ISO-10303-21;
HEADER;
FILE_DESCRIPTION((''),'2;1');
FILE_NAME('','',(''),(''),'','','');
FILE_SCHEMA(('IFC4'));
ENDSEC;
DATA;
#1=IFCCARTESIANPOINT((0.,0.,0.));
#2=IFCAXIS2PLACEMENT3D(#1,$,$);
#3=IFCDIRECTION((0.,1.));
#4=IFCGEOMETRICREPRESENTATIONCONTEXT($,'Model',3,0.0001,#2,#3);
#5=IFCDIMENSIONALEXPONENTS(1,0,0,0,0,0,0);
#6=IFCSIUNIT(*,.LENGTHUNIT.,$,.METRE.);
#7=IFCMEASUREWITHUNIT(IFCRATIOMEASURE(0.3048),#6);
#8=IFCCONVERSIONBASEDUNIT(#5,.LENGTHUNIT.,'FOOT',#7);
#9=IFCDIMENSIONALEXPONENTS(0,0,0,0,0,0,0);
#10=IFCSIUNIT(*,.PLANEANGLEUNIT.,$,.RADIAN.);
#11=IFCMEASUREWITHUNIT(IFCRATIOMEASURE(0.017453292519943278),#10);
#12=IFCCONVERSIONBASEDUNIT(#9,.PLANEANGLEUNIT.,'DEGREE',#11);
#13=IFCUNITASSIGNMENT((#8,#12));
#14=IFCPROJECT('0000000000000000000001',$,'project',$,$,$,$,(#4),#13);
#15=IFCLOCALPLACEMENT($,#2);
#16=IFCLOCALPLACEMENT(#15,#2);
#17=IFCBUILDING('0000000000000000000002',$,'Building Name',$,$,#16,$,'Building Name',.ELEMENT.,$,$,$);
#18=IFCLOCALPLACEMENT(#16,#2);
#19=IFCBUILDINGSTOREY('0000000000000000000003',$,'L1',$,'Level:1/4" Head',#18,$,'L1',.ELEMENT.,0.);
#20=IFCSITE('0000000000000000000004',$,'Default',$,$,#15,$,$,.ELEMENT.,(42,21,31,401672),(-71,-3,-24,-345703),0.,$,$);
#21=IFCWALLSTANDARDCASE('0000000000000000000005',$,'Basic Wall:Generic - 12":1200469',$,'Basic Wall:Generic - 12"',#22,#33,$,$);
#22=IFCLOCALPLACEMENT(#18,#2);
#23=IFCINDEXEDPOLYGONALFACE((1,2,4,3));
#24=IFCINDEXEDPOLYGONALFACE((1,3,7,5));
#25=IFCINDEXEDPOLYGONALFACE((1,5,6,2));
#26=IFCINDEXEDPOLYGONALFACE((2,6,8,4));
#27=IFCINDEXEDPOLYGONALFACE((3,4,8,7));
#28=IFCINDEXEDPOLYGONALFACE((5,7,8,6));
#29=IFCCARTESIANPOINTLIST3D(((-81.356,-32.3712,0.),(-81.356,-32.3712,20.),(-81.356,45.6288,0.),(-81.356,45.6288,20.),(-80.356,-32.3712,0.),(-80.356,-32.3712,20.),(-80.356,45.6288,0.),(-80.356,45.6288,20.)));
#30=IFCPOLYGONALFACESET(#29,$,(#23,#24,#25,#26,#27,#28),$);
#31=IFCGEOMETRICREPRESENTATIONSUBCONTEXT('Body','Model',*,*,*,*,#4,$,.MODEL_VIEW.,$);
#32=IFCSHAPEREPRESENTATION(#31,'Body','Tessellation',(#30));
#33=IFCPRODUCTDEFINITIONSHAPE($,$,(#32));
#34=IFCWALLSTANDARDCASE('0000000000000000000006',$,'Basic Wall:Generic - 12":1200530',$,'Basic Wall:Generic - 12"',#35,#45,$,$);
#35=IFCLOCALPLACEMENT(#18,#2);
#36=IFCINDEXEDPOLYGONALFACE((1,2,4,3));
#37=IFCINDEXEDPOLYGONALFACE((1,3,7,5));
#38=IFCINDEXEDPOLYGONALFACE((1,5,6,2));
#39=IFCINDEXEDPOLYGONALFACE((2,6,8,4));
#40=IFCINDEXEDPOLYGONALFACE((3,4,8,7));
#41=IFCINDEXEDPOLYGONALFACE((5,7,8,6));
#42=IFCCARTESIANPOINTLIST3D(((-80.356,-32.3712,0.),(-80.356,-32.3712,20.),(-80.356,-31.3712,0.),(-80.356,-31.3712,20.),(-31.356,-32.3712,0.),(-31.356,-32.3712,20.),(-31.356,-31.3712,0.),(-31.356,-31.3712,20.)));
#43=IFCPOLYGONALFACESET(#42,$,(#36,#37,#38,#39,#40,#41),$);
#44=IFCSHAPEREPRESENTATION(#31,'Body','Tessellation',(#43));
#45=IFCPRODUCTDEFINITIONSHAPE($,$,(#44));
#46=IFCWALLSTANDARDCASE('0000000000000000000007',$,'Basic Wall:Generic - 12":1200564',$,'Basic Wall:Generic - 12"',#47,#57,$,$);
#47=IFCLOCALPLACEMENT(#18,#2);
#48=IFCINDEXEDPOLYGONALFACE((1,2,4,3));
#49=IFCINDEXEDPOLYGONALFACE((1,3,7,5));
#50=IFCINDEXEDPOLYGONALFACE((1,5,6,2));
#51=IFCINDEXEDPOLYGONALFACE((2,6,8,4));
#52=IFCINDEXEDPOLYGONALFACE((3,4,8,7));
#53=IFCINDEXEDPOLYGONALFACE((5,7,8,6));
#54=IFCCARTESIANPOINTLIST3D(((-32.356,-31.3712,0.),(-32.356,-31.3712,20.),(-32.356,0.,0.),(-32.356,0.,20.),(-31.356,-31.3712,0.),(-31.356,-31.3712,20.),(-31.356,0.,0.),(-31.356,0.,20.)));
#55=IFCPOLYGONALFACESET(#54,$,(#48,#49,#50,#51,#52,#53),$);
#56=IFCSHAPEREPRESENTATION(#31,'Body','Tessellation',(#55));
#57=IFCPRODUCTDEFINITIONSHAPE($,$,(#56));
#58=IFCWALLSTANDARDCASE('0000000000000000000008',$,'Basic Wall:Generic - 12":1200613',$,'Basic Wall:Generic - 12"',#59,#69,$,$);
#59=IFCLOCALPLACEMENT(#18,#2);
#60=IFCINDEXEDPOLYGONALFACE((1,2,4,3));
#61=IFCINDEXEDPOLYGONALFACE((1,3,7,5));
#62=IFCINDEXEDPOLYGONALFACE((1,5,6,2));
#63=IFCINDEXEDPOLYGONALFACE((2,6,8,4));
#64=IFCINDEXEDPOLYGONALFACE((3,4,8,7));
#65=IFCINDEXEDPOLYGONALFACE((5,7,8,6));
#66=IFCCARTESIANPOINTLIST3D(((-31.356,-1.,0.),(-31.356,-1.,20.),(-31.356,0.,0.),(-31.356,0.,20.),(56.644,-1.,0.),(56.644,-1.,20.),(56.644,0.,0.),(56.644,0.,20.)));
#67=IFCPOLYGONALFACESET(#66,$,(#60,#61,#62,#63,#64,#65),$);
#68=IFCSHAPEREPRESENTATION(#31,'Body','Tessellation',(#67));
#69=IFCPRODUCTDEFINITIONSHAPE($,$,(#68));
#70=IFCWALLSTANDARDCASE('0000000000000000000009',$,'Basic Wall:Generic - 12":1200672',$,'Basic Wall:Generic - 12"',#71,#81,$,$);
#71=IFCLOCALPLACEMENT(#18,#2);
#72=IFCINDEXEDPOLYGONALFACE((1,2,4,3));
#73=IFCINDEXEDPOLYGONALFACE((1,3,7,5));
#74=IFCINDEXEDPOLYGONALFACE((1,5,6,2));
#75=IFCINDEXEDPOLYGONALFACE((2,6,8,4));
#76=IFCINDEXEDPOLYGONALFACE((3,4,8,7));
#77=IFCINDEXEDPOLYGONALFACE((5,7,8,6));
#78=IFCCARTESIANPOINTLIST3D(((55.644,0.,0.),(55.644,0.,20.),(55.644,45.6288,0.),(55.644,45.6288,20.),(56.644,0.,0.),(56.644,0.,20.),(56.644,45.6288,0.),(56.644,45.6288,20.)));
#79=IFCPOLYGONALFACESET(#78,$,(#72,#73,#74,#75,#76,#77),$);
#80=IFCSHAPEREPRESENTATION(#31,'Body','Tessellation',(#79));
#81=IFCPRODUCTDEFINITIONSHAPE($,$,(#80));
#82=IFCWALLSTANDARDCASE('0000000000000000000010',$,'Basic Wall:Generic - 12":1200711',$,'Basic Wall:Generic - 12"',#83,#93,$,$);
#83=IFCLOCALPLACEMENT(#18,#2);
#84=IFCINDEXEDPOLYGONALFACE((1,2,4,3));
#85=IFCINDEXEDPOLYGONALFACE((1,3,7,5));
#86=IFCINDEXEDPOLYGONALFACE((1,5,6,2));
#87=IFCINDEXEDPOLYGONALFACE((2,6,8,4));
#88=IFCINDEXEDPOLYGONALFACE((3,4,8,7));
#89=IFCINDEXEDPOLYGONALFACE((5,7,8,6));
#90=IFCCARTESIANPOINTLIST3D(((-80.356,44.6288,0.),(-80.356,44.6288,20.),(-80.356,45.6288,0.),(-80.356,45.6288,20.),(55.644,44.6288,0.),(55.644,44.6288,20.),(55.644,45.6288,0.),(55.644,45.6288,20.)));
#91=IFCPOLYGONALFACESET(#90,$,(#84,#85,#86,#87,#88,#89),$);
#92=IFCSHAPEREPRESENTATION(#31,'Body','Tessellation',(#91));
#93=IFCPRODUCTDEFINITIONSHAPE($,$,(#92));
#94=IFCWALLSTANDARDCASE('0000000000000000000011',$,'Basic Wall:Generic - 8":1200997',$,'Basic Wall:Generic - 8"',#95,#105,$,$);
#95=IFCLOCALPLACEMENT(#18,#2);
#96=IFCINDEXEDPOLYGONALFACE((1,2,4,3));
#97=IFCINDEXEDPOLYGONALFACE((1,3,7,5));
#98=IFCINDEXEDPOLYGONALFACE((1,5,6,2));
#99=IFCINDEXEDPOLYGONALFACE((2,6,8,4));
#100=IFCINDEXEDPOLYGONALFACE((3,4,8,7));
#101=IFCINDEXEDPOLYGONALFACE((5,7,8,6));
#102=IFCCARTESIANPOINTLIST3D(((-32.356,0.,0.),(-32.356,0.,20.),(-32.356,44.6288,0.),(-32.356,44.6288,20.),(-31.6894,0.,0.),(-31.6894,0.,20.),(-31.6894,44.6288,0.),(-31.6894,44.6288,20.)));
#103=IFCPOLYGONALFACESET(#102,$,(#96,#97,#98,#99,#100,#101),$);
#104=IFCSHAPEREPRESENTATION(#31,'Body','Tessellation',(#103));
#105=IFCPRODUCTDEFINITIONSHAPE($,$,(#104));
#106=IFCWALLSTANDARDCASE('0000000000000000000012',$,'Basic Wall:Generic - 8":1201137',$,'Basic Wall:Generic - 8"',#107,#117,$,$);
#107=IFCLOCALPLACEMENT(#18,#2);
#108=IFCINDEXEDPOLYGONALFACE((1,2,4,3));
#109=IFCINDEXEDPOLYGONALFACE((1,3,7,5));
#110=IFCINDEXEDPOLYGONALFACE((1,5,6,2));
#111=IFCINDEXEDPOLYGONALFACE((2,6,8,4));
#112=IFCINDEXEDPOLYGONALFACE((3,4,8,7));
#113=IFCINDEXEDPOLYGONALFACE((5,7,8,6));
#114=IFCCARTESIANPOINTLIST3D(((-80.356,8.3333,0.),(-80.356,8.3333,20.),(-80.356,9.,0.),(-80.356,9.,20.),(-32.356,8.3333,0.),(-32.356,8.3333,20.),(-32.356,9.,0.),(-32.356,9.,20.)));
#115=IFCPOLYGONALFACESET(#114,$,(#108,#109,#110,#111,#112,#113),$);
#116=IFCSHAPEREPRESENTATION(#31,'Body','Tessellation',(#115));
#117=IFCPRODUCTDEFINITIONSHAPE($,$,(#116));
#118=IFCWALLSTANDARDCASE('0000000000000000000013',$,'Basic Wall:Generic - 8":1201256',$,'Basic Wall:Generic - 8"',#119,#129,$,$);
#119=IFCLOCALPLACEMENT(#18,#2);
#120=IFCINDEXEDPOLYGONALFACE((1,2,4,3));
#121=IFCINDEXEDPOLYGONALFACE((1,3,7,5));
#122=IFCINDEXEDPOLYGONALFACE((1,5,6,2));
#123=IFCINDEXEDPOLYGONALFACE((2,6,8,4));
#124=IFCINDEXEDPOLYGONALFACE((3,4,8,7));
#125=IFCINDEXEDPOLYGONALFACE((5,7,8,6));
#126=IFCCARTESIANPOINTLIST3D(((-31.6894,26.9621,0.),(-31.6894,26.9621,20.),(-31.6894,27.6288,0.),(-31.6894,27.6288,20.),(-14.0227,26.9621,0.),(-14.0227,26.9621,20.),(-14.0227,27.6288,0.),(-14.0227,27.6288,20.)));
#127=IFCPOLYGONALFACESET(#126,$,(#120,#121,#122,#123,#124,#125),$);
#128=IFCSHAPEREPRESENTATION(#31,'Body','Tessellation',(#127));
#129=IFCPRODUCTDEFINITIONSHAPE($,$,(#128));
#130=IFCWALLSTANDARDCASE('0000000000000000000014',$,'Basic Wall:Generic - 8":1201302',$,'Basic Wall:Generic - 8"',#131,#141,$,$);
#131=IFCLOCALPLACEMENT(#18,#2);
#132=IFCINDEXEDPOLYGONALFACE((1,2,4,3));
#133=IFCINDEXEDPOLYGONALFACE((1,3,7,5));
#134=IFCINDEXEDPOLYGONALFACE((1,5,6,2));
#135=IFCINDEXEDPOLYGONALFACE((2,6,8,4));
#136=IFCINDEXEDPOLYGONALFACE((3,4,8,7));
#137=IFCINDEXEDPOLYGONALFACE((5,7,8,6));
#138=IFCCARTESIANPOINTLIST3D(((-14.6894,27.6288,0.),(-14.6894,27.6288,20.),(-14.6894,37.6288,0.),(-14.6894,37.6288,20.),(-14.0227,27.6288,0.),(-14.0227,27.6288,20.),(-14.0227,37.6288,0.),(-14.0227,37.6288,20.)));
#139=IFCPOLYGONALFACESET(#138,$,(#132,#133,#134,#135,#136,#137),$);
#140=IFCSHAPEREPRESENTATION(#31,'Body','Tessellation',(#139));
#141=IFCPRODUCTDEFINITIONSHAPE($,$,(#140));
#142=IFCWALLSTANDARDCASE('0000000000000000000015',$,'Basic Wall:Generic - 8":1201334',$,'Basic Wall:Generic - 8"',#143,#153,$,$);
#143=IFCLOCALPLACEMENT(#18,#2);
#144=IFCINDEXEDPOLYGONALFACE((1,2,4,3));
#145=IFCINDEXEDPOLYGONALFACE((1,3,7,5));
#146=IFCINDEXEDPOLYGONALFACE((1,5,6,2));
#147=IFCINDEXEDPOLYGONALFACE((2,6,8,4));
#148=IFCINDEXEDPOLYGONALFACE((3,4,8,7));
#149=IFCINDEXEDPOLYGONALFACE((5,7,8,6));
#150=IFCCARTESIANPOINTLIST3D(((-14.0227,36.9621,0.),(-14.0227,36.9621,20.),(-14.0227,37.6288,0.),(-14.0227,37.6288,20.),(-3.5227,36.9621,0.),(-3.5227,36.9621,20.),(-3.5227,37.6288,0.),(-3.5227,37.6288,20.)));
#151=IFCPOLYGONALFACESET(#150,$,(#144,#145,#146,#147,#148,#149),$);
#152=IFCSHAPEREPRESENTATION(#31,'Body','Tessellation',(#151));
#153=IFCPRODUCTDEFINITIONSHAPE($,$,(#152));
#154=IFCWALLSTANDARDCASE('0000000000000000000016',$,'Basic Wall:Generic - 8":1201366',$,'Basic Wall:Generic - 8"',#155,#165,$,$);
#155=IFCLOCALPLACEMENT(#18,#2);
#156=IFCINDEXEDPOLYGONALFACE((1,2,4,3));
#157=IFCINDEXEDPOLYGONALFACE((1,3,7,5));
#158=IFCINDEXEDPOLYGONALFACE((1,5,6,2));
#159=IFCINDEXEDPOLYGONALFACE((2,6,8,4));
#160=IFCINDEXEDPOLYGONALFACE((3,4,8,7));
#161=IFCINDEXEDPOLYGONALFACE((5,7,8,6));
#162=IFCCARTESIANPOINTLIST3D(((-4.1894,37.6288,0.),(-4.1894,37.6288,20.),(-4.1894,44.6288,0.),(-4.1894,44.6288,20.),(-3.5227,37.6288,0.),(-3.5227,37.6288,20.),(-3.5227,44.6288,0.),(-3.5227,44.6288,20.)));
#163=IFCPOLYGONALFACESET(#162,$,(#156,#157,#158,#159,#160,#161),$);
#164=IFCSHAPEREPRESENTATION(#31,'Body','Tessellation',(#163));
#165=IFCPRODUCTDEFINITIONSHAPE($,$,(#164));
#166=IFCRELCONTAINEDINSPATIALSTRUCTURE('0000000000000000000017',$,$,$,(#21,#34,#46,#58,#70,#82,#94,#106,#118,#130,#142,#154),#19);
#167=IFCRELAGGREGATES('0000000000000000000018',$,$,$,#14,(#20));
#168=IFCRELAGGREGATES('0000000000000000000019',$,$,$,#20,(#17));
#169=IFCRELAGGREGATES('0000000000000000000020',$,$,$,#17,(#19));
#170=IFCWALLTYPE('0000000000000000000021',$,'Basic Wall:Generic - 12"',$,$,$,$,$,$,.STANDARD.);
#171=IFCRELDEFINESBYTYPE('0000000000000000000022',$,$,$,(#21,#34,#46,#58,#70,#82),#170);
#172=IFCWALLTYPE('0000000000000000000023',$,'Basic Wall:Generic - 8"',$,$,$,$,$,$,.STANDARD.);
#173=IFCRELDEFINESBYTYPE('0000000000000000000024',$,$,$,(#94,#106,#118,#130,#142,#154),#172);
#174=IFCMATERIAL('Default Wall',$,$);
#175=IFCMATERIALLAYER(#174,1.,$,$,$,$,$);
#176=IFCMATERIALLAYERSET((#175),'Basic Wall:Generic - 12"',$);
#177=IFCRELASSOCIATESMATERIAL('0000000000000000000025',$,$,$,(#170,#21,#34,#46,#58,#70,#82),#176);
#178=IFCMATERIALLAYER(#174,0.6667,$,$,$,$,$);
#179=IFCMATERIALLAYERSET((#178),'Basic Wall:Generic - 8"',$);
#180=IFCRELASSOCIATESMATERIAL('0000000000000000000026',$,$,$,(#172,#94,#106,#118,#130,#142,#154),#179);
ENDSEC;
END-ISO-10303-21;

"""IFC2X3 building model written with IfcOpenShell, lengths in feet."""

from ifc_helpers import new_model, entity, si_unit, converted_unit, direction, frame, frame_2d, origin, place, context, subcontext, project, spatial, rectangle, extrude, material, layer, layer_set, layer_usage, type_object, element, save


model = new_model("IFC2X3")

# Units and contexts
model_context = context("Model", 3, precision=0.0001, world=origin(), true_north=direction((0.0, 1.0)))
body_context = subcontext(model_context, "Body", "Model", "MODEL_VIEW")
ifc_project = project(units=[converted_unit("LENGTHUNIT", "FOOT", entity("IfcRatioMeasure", 0.3048), si_unit("LENGTHUNIT", "METRE"), dimensions=[1, 0, 0, 0, 0, 0, 0]), converted_unit("PLANEANGLEUNIT", "DEGREE", entity("IfcRatioMeasure", 0.017453292519943278), si_unit("PLANEANGLEUNIT", "RADIAN"), dimensions=[0, 0, 0, 0, 0, 0, 0])], contexts=[model_context])

# Site, building, storey
site_placement = place(None, origin())
site = spatial("IfcSite", under=ifc_project, at=site_placement, Name="Default", CompositionType="ELEMENT", RefLatitude=(42, 21, 31, 401672), RefLongitude=(-71, -3, -24, -345703), RefElevation=0.0)
building_placement = place(site_placement, origin())
building = spatial("IfcBuilding", under=site, at=building_placement, Name="Building Name", LongName="Building Name", CompositionType="ELEMENT")
storey_placement = place(building_placement, origin())
storey = spatial("IfcBuildingStorey", under=building, at=storey_placement, Name="L1", ObjectType="Level:1/4\" Head", LongName="L1", CompositionType="ELEMENT", Elevation=0.0)

# Walls
ifc_material = material(Name="Default Wall")
ifc_layer_1 = layer(ifc_material, 1.0)
ifc_layer_set_1 = layer_set([ifc_layer_1], Name="Basic Wall:Generic - 12\"")
ifc_layer_usage_1 = layer_usage(ifc_layer_set_1, "AXIS2", "NEGATIVE", 0.5)
wall_type_1 = type_object("IfcWallType", Name="Basic Wall:Generic - 12\"", PredefinedType="STANDARD", material=ifc_layer_set_1)
wall_1_placement = place(storey_placement, frame((-80.856, 45.6288, 0.0), z_axis=(0.0, 0.0, 1.0), x_axis=(0.0, -1.0, 0.0)))
element("IfcWallStandardCase", 1, at=wall_1_placement, inside=storey, type_object=wall_type_1, material=ifc_layer_usage_1, Name="Basic Wall:Generic - 12\":1200469", ObjectType="Basic Wall:Generic - 12\"", context=body_context, shape_type="SweptSolid", body=[
    extrude(rectangle(XDim=78.0, YDim=1.0, at=frame_2d((39.0, 0.0), x_axis=(-1.0, 0.0))), origin(), (0.0, 0.0, 1.0), 20.0),
])
wall_2_placement = place(storey_placement, frame((-80.356, -31.8712, 0.0)))
element("IfcWallStandardCase", 2, at=wall_2_placement, inside=storey, type_object=wall_type_1, material=ifc_layer_usage_1, Name="Basic Wall:Generic - 12\":1200530", ObjectType="Basic Wall:Generic - 12\"", context=body_context, shape_type="SweptSolid", body=[
    extrude(rectangle(XDim=49.0, YDim=1.0, at=frame_2d((24.5, 0.0), x_axis=(-1.0, 0.0))), origin(), (0.0, 0.0, 1.0), 20.0),
])
wall_3_placement = place(storey_placement, frame((-31.856, -31.3712, 0.0), z_axis=(0.0, 0.0, 1.0), x_axis=(0.0, 1.0, 0.0)))
element("IfcWallStandardCase", 3, at=wall_3_placement, inside=storey, type_object=wall_type_1, material=ifc_layer_usage_1, Name="Basic Wall:Generic - 12\":1200564", ObjectType="Basic Wall:Generic - 12\"", context=body_context, shape_type="SweptSolid", body=[
    extrude(rectangle(XDim=31.3712, YDim=1.0, at=frame_2d((15.6856, 0.0), x_axis=(-1.0, 0.0))), origin(), (0.0, 0.0, 1.0), 20.0),
])
wall_4_placement = place(storey_placement, frame((-31.356, -0.5, 0.0)))
element("IfcWallStandardCase", 4, at=wall_4_placement, inside=storey, type_object=wall_type_1, material=ifc_layer_usage_1, Name="Basic Wall:Generic - 12\":1200613", ObjectType="Basic Wall:Generic - 12\"", context=body_context, shape_type="SweptSolid", body=[
    extrude(rectangle(XDim=88.0, YDim=1.0, at=frame_2d((44.0, 0.0), x_axis=(-1.0, 0.0))), origin(), (0.0, 0.0, 1.0), 20.0),
])
wall_5_placement = place(storey_placement, frame((56.144, 0.0, 0.0), z_axis=(0.0, 0.0, 1.0), x_axis=(0.0, 1.0, 0.0)))
element("IfcWallStandardCase", 5, at=wall_5_placement, inside=storey, type_object=wall_type_1, material=ifc_layer_usage_1, Name="Basic Wall:Generic - 12\":1200672", ObjectType="Basic Wall:Generic - 12\"", context=body_context, shape_type="SweptSolid", body=[
    extrude(rectangle(XDim=45.6288, YDim=1.0, at=frame_2d((22.8144, 0.0), x_axis=(-1.0, 0.0))), origin(), (0.0, 0.0, 1.0), 20.0),
])
wall_6_placement = place(storey_placement, frame((55.644, 45.1288, 0.0), z_axis=(0.0, 0.0, 1.0), x_axis=(-1.0, 0.0, 0.0)))
element("IfcWallStandardCase", 6, at=wall_6_placement, inside=storey, type_object=wall_type_1, material=ifc_layer_usage_1, Name="Basic Wall:Generic - 12\":1200711", ObjectType="Basic Wall:Generic - 12\"", context=body_context, shape_type="SweptSolid", body=[
    extrude(rectangle(XDim=136.0, YDim=1.0, at=frame_2d((68.0, 0.0), x_axis=(-1.0, 0.0))), origin(), (0.0, 0.0, 1.0), 20.0),
])
ifc_layer_2 = layer(ifc_material, 0.6667)
ifc_layer_set_2 = layer_set([ifc_layer_2], Name="Basic Wall:Generic - 8\"")
ifc_layer_usage_2 = layer_usage(ifc_layer_set_2, "AXIS2", "NEGATIVE", 0.3333)
wall_type_2 = type_object("IfcWallType", Name="Basic Wall:Generic - 8\"", PredefinedType="STANDARD", material=ifc_layer_set_2)
wall_7_placement = place(storey_placement, frame((-32.0227, 0.0, 0.0), z_axis=(0.0, 0.0, 1.0), x_axis=(0.0, 1.0, 0.0)))
element("IfcWallStandardCase", 7, at=wall_7_placement, inside=storey, type_object=wall_type_2, material=ifc_layer_usage_2, Name="Basic Wall:Generic - 8\":1200997", ObjectType="Basic Wall:Generic - 8\"", context=body_context, shape_type="SweptSolid", body=[
    extrude(rectangle(XDim=44.6288, YDim=0.6667, at=frame_2d((22.3144, 0.0), x_axis=(-1.0, 0.0))), origin(), (0.0, 0.0, 1.0), 20.0),
])
wall_8_placement = place(storey_placement, frame((-80.356, 8.6667, 0.0)))
element("IfcWallStandardCase", 8, at=wall_8_placement, inside=storey, type_object=wall_type_2, material=ifc_layer_usage_2, Name="Basic Wall:Generic - 8\":1201137", ObjectType="Basic Wall:Generic - 8\"", context=body_context, shape_type="SweptSolid", body=[
    extrude(rectangle(XDim=48.0, YDim=0.6667, at=frame_2d((24.0, 0.0), x_axis=(-1.0, 0.0))), origin(), (0.0, 0.0, 1.0), 20.0),
])
wall_9_placement = place(storey_placement, frame((-31.6894, 27.2955, 0.0)))
element("IfcWallStandardCase", 9, at=wall_9_placement, inside=storey, type_object=wall_type_2, material=ifc_layer_usage_2, Name="Basic Wall:Generic - 8\":1201256", ObjectType="Basic Wall:Generic - 8\"", context=body_context, shape_type="SweptSolid", body=[
    extrude(rectangle(XDim=17.6667, YDim=0.6667, at=frame_2d((8.8333, 0.0), x_axis=(-1.0, 0.0))), origin(), (0.0, 0.0, 1.0), 20.0),
])
wall_10_placement = place(storey_placement, frame((-14.356, 27.6288, 0.0), z_axis=(0.0, 0.0, 1.0), x_axis=(0.0, 1.0, 0.0)))
element("IfcWallStandardCase", 10, at=wall_10_placement, inside=storey, type_object=wall_type_2, material=ifc_layer_usage_2, Name="Basic Wall:Generic - 8\":1201302", ObjectType="Basic Wall:Generic - 8\"", context=body_context, shape_type="SweptSolid", body=[
    extrude(rectangle(XDim=10.0, YDim=0.6667, at=frame_2d((5.0, 0.0), x_axis=(-1.0, 0.0))), origin(), (0.0, 0.0, 1.0), 20.0),
])
wall_11_placement = place(storey_placement, frame((-14.0227, 37.2955, 0.0)))
element("IfcWallStandardCase", 11, at=wall_11_placement, inside=storey, type_object=wall_type_2, material=ifc_layer_usage_2, Name="Basic Wall:Generic - 8\":1201334", ObjectType="Basic Wall:Generic - 8\"", context=body_context, shape_type="SweptSolid", body=[
    extrude(rectangle(XDim=10.5, YDim=0.6667, at=frame_2d((5.25, 0.0), x_axis=(-1.0, 0.0))), origin(), (0.0, 0.0, 1.0), 20.0),
])
wall_12_placement = place(storey_placement, frame((-3.856, 37.6288, 0.0), z_axis=(0.0, 0.0, 1.0), x_axis=(0.0, 1.0, 0.0)))
element("IfcWallStandardCase", 12, at=wall_12_placement, inside=storey, type_object=wall_type_2, material=ifc_layer_usage_2, Name="Basic Wall:Generic - 8\":1201366", ObjectType="Basic Wall:Generic - 8\"", context=body_context, shape_type="SweptSolid", body=[
    extrude(rectangle(XDim=7.0, YDim=0.6667, at=frame_2d((3.5, 0.0), x_axis=(-1.0, 0.0))), origin(), (0.0, 0.0, 1.0), 20.0),
])

save(model, "model.ifc")
